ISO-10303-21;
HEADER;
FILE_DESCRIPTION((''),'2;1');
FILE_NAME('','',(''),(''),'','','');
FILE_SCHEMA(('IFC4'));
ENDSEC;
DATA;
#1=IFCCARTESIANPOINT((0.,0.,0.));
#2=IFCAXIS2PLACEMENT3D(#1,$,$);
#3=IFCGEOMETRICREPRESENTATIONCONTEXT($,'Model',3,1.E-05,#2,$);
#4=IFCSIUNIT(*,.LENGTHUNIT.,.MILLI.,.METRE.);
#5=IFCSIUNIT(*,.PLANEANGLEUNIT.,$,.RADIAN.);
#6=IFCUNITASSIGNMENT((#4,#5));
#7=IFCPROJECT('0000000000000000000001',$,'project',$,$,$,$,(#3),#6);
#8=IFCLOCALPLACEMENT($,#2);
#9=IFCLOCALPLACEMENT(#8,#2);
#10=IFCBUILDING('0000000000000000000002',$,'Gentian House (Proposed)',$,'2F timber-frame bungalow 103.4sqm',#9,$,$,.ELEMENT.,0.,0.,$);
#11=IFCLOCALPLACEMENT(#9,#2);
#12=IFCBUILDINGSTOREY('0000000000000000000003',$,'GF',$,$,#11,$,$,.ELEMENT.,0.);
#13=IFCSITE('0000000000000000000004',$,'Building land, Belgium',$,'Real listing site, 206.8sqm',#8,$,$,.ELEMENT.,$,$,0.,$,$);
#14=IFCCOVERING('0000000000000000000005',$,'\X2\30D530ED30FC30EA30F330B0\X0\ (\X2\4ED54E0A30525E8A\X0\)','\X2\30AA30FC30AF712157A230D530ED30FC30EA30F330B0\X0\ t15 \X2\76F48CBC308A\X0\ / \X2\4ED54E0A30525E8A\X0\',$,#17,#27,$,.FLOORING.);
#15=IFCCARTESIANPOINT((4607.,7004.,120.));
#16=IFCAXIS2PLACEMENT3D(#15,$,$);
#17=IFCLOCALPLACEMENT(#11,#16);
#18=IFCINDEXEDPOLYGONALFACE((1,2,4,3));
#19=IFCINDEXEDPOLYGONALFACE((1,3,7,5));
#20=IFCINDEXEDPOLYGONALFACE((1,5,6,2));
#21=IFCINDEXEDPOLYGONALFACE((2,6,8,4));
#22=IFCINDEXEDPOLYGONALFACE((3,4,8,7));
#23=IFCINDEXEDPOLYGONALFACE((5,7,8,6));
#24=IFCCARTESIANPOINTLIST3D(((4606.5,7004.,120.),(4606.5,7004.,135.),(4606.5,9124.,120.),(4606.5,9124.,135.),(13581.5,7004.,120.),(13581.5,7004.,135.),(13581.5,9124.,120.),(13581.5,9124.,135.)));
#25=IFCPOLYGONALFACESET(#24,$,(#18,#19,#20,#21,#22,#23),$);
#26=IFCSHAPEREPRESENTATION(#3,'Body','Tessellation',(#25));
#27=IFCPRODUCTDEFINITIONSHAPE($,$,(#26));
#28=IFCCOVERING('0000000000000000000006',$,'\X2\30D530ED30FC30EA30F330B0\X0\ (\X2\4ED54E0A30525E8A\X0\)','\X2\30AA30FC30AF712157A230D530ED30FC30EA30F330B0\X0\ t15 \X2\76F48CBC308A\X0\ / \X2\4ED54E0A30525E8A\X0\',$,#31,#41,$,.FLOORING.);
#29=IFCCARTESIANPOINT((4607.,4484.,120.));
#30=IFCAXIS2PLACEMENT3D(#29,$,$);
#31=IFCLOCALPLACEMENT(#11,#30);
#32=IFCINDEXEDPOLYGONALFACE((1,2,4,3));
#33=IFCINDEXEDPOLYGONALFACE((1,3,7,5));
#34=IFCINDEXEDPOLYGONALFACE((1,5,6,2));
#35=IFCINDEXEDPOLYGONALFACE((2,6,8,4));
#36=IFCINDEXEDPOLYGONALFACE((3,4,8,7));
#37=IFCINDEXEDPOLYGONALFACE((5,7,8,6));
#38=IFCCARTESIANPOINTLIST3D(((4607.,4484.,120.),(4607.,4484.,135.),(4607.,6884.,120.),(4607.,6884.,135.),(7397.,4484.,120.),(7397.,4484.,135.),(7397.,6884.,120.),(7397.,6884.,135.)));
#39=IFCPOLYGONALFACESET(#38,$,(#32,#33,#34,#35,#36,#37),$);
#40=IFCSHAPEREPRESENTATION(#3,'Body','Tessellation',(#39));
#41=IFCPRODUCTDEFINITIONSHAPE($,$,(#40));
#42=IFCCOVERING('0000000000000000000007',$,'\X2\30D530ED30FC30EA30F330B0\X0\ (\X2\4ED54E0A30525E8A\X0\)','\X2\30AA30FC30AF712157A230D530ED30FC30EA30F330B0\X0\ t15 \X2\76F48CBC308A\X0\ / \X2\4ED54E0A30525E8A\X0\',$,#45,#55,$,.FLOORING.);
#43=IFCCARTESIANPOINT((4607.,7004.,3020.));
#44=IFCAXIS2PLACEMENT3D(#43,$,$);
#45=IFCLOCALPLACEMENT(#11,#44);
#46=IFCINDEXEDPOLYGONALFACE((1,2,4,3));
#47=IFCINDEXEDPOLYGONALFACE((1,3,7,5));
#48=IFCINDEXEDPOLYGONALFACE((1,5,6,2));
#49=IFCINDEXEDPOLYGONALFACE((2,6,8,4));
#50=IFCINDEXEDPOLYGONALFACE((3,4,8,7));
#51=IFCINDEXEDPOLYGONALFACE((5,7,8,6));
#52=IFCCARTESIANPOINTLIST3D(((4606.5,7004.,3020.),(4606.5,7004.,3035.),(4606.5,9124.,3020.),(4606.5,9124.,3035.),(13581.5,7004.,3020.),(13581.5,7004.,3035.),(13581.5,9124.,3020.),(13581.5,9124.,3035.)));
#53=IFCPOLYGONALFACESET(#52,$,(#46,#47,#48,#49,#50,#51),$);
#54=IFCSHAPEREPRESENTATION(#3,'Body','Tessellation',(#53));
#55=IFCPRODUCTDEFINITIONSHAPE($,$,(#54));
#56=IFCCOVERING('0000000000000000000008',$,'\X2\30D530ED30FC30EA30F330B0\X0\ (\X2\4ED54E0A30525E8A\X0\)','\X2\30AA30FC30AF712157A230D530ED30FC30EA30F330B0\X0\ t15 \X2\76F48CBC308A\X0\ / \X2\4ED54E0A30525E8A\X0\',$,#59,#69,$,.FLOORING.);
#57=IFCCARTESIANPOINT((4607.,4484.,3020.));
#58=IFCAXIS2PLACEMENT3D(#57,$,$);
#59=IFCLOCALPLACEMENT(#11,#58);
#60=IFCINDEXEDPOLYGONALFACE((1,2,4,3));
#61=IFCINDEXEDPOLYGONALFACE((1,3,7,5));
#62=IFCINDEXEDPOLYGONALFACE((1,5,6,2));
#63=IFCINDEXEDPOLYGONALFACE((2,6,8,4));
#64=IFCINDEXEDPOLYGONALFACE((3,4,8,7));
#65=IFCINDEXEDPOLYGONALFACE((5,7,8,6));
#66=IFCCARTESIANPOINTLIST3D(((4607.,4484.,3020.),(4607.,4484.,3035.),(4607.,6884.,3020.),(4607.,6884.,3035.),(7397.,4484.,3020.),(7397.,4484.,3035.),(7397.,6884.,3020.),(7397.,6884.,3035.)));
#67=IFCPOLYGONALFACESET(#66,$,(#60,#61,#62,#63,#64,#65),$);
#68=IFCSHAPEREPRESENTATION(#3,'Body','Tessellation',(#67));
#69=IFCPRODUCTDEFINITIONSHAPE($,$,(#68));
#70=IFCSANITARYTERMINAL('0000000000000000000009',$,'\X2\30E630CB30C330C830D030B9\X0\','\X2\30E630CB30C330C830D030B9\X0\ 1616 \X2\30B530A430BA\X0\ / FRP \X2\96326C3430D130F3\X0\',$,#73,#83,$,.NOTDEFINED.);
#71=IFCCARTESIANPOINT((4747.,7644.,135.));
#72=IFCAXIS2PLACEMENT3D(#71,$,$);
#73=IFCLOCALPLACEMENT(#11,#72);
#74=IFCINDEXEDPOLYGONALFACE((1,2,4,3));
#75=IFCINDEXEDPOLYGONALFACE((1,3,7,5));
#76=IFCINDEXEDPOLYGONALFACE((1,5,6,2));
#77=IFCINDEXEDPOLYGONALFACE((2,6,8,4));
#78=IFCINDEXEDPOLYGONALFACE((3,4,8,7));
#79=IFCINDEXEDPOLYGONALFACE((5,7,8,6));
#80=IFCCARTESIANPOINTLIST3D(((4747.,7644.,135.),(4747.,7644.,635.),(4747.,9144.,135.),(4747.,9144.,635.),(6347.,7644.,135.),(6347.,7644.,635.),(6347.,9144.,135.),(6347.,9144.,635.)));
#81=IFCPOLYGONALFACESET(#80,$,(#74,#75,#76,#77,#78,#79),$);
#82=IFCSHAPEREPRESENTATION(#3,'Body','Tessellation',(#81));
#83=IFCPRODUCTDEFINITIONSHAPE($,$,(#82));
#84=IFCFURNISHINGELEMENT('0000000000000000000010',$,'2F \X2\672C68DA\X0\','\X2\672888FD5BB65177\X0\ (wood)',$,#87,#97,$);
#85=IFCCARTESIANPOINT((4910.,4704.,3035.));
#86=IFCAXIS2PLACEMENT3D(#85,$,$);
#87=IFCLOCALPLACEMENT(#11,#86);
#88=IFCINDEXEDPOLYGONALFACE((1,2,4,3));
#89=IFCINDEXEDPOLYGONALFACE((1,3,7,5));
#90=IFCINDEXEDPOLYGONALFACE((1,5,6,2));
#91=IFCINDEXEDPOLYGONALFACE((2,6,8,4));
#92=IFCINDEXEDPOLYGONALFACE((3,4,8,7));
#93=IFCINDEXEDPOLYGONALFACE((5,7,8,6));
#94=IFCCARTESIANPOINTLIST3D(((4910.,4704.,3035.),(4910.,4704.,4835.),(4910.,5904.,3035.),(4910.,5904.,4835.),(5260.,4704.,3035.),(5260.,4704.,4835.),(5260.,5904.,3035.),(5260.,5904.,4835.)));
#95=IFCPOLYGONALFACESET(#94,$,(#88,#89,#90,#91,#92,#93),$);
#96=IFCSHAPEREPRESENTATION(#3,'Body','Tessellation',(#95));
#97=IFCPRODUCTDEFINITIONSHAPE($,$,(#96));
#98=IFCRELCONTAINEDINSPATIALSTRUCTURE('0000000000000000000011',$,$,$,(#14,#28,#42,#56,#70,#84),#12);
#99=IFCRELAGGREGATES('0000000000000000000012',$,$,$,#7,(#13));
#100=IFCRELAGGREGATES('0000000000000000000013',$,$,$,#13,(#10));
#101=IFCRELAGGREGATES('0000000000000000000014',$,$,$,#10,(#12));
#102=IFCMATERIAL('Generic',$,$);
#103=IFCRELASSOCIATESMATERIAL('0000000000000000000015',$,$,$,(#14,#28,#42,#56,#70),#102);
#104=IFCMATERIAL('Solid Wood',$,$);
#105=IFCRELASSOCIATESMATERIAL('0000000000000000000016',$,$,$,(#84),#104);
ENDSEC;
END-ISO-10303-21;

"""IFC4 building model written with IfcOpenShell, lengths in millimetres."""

from ifc_helpers import new_model, si_unit, frame, frame_2d, origin, place, context, project, spatial, rectangle, extrude, material, element, save


model = new_model("IFC4")

# Units and contexts
model_context = context("Model", 3, precision=1e-05, world=origin())
ifc_project = project(units=[si_unit("LENGTHUNIT", "METRE", prefix="MILLI"), si_unit("PLANEANGLEUNIT", "RADIAN")], contexts=[model_context])

# Site, building, storey
site_placement = place(None, origin())
site = spatial("IfcSite", under=ifc_project, at=site_placement, Name="Building land, Belgium", ObjectType="Real listing site, 206.8sqm", CompositionType="ELEMENT", RefElevation=0.0)
building_placement = place(site_placement, origin())
building = spatial("IfcBuilding", under=site, at=building_placement, Name="Gentian House (Proposed)", ObjectType="2F timber-frame bungalow 103.4sqm", CompositionType="ELEMENT", ElevationOfRefHeight=0.0, ElevationOfTerrain=0.0)
storey_placement = place(building_placement, origin())
storey = spatial("IfcBuildingStorey", under=building, at=storey_placement, Name="GF", CompositionType="ELEMENT", Elevation=0.0)

# Shared definitions
ifc_material_1 = material(Name="Solid Wood")

# Coverings
ifc_material_2 = material(Name="Generic")
covering_1_placement = place(storey_placement, frame((4607.0, 7004.0, 120.0)))
element("IfcCovering", 1, at=covering_1_placement, inside=storey, material=ifc_material_2, Name="フローリング (仕上げ床)", Description="オーク無垢フローリング t15 直貼り / 仕上げ床", PredefinedType="FLOORING", context=model_context, shape_type="SweptSolid", body=[
    extrude(rectangle(XDim=8975.0, YDim=2120.0, at=frame_2d((4487.0, 1060.0))), frame((4607.0, 7004.0, 120.0)), (0.0, 0.0, 1.0), 15.0),
])
covering_2_placement = place(storey_placement, frame((4607.0, 4484.0, 120.0)))
element("IfcCovering", 2, at=covering_2_placement, inside=storey, material=ifc_material_2, Name="フローリング (仕上げ床)", Description="オーク無垢フローリング t15 直貼り / 仕上げ床", PredefinedType="FLOORING", context=model_context, shape_type="SweptSolid", body=[
    extrude(rectangle(XDim=2790.0, YDim=2400.0, at=frame_2d((1395.0, 1200.0))), frame((4607.0, 4484.0, 120.0)), (0.0, 0.0, 1.0), 15.0),
])
covering_3_placement = place(storey_placement, frame((4607.0, 7004.0, 3020.0)))
element("IfcCovering", 3, at=covering_3_placement, inside=storey, material=ifc_material_2, Name="フローリング (仕上げ床)", Description="オーク無垢フローリング t15 直貼り / 仕上げ床", PredefinedType="FLOORING", context=model_context, shape_type="SweptSolid", body=[
    extrude(rectangle(XDim=8975.0, YDim=2120.0, at=frame_2d((4487.0, 1060.0))), frame((4607.0, 7004.0, 3020.0)), (0.0, 0.0, 1.0), 15.0),
])
covering_4_placement = place(storey_placement, frame((4607.0, 4484.0, 3020.0)))
element("IfcCovering", 4, at=covering_4_placement, inside=storey, material=ifc_material_2, Name="フローリング (仕上げ床)", Description="オーク無垢フローリング t15 直貼り / 仕上げ床", PredefinedType="FLOORING", context=model_context, shape_type="SweptSolid", body=[
    extrude(rectangle(XDim=2790.0, YDim=2400.0, at=frame_2d((1395.0, 1200.0))), frame((4607.0, 4484.0, 3020.0)), (0.0, 0.0, 1.0), 15.0),
])

# Sanitary terminal
sanitary_terminal_placement = place(storey_placement, frame((4747.0, 7644.0, 135.0)))
element("IfcSanitaryTerminal", 5, at=sanitary_terminal_placement, inside=storey, material=ifc_material_2, Name="ユニットバス", Description="ユニットバス 1616 サイズ / FRP 防水パン", PredefinedType="NOTDEFINED", context=model_context, shape_type="SweptSolid", body=[
    extrude(rectangle(XDim=1600.0, YDim=1500.0, at=frame_2d((800.0, 750.0))), frame((4747.0, 7644.0, 135.0)), (0.0, 0.0, 1.0), 500.0),
])

# Furnishing element
furnishing_placement = place(storey_placement, frame((4910.0, 4704.0, 3035.0)))
element("IfcFurnishingElement", 6, at=furnishing_placement, inside=storey, material=ifc_material_1, Name="2F 本棚", Description="木製家具 (wood)", context=model_context, shape_type="SweptSolid", body=[
    extrude(rectangle(XDim=350.0, YDim=1200.0, at=frame_2d((175.0, 600.0))), frame((4910.0, 4704.0, 3035.0)), (0.0, 0.0, 1.0), 1800.0),
])

save(model, "model.ifc")
